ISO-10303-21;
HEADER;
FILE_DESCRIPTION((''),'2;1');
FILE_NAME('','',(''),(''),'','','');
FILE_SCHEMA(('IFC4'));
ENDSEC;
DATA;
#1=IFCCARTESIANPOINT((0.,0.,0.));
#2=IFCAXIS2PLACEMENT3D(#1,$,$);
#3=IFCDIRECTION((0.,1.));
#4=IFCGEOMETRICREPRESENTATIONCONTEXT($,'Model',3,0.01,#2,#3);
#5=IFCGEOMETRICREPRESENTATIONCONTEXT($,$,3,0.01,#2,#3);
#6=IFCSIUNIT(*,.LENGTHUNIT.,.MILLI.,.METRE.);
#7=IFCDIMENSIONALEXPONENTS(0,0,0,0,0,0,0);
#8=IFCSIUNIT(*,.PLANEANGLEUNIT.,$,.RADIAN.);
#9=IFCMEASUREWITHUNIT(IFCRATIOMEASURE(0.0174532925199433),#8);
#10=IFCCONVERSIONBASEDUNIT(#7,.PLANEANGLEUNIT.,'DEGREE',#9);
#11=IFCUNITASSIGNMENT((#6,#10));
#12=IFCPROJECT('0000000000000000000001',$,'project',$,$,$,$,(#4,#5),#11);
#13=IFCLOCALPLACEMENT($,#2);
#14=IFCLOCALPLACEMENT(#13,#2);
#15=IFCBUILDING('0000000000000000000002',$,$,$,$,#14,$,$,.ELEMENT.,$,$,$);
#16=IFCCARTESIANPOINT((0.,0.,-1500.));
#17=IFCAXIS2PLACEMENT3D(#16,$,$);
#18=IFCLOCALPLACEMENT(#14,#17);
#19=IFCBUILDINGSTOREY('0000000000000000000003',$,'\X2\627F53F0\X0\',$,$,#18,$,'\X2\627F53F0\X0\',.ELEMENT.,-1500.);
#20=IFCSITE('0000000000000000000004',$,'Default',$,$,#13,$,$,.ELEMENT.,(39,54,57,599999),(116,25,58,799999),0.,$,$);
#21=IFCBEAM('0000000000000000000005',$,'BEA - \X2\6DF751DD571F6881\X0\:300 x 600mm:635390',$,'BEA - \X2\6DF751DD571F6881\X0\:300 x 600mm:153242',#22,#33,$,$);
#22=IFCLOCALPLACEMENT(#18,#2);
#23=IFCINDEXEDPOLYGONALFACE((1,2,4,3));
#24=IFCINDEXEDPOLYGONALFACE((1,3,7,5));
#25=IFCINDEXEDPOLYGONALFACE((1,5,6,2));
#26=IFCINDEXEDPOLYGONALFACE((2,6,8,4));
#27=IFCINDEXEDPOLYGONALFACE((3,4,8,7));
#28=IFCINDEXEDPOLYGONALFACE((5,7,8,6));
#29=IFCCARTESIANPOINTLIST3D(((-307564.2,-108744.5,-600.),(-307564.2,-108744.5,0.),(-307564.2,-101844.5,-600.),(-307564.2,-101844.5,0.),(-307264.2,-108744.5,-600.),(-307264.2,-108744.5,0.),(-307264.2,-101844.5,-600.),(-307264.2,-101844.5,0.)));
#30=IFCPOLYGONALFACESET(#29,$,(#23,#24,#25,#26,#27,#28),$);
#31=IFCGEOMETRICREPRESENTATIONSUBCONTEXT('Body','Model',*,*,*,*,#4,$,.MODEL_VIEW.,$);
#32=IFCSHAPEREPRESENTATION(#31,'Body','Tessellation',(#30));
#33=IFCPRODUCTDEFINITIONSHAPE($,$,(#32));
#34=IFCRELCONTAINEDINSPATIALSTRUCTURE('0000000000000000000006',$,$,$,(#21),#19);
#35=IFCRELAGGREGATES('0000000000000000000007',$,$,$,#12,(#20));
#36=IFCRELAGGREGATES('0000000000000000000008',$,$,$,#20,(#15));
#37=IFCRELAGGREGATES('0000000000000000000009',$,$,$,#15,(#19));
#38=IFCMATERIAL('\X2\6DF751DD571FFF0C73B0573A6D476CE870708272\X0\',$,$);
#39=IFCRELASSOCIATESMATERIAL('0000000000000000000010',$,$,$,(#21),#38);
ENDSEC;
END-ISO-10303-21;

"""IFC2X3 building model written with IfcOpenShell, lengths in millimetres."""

from ifc_helpers import new_model, entity, si_unit, converted_unit, direction, frame, origin, origin_2d_with_axis, place, context, subcontext, project, spatial, rectangle, extrude, material, element, save


model = new_model("IFC2X3")

# Units and contexts
model_context = context("Model", 3, precision=0.01, world=origin(), true_north=direction((0.0, 1.0)))
context_of_model = context(None, 3, precision=0.01, world=origin(), true_north=direction((0.0, 1.0)))
body_context = subcontext(model_context, "Body", "Model", "MODEL_VIEW")
ifc_project = project(units=[si_unit("LENGTHUNIT", "METRE", prefix="MILLI"), converted_unit("PLANEANGLEUNIT", "DEGREE", entity("IfcRatioMeasure", 0.0174532925199433), si_unit("PLANEANGLEUNIT", "RADIAN"), dimensions=[0, 0, 0, 0, 0, 0, 0])], contexts=[model_context, context_of_model])

# Site, building, storey
site_placement = place(None, origin())
site = spatial("IfcSite", under=ifc_project, at=site_placement, Name="Default", CompositionType="ELEMENT", RefLatitude=(39, 54, 57, 599999), RefLongitude=(116, 25, 58, 799999), RefElevation=0.0)
building_placement = place(site_placement, origin())
building = spatial("IfcBuilding", under=site, at=building_placement, CompositionType="ELEMENT")
storey_placement = place(building_placement, frame((0.0, 0.0, -1500.0)))
storey = spatial("IfcBuildingStorey", under=building, at=storey_placement, Name="承台", LongName="承台", CompositionType="ELEMENT", Elevation=-1500.0)

# Shared definitions
ifc_material_1 = material(Name="混凝土，现场浇注灰色")

# Beam
for number, where, z_axis, x_axis, name in (
    (1, (-307414.2, -101844.5, 0.0), (0.0, 0.0, 1.0), (0.0, -1.0, 0.0), "BEA - 混凝土梁:300 x 600mm:635390"),
):
    element("IfcBeam", number, at=place(storey_placement, frame(where, z_axis=z_axis, x_axis=x_axis)), inside=storey, material=ifc_material_1, Name=name, ObjectType="BEA - 混凝土梁:300 x 600mm:153242", context=body_context, shape_type="SweptSolid", body=[
        extrude(rectangle(XDim=600.0, YDim=300.0, at=origin_2d_with_axis()), frame((0.0, 0.0, -300.0), z_axis=(1.0, 0.0, 0.0), x_axis=(0.0, 0.0, -1.0)), (0.0, 0.0, 1.0), 6900.0),
    ])

save(model, "model.ifc")
